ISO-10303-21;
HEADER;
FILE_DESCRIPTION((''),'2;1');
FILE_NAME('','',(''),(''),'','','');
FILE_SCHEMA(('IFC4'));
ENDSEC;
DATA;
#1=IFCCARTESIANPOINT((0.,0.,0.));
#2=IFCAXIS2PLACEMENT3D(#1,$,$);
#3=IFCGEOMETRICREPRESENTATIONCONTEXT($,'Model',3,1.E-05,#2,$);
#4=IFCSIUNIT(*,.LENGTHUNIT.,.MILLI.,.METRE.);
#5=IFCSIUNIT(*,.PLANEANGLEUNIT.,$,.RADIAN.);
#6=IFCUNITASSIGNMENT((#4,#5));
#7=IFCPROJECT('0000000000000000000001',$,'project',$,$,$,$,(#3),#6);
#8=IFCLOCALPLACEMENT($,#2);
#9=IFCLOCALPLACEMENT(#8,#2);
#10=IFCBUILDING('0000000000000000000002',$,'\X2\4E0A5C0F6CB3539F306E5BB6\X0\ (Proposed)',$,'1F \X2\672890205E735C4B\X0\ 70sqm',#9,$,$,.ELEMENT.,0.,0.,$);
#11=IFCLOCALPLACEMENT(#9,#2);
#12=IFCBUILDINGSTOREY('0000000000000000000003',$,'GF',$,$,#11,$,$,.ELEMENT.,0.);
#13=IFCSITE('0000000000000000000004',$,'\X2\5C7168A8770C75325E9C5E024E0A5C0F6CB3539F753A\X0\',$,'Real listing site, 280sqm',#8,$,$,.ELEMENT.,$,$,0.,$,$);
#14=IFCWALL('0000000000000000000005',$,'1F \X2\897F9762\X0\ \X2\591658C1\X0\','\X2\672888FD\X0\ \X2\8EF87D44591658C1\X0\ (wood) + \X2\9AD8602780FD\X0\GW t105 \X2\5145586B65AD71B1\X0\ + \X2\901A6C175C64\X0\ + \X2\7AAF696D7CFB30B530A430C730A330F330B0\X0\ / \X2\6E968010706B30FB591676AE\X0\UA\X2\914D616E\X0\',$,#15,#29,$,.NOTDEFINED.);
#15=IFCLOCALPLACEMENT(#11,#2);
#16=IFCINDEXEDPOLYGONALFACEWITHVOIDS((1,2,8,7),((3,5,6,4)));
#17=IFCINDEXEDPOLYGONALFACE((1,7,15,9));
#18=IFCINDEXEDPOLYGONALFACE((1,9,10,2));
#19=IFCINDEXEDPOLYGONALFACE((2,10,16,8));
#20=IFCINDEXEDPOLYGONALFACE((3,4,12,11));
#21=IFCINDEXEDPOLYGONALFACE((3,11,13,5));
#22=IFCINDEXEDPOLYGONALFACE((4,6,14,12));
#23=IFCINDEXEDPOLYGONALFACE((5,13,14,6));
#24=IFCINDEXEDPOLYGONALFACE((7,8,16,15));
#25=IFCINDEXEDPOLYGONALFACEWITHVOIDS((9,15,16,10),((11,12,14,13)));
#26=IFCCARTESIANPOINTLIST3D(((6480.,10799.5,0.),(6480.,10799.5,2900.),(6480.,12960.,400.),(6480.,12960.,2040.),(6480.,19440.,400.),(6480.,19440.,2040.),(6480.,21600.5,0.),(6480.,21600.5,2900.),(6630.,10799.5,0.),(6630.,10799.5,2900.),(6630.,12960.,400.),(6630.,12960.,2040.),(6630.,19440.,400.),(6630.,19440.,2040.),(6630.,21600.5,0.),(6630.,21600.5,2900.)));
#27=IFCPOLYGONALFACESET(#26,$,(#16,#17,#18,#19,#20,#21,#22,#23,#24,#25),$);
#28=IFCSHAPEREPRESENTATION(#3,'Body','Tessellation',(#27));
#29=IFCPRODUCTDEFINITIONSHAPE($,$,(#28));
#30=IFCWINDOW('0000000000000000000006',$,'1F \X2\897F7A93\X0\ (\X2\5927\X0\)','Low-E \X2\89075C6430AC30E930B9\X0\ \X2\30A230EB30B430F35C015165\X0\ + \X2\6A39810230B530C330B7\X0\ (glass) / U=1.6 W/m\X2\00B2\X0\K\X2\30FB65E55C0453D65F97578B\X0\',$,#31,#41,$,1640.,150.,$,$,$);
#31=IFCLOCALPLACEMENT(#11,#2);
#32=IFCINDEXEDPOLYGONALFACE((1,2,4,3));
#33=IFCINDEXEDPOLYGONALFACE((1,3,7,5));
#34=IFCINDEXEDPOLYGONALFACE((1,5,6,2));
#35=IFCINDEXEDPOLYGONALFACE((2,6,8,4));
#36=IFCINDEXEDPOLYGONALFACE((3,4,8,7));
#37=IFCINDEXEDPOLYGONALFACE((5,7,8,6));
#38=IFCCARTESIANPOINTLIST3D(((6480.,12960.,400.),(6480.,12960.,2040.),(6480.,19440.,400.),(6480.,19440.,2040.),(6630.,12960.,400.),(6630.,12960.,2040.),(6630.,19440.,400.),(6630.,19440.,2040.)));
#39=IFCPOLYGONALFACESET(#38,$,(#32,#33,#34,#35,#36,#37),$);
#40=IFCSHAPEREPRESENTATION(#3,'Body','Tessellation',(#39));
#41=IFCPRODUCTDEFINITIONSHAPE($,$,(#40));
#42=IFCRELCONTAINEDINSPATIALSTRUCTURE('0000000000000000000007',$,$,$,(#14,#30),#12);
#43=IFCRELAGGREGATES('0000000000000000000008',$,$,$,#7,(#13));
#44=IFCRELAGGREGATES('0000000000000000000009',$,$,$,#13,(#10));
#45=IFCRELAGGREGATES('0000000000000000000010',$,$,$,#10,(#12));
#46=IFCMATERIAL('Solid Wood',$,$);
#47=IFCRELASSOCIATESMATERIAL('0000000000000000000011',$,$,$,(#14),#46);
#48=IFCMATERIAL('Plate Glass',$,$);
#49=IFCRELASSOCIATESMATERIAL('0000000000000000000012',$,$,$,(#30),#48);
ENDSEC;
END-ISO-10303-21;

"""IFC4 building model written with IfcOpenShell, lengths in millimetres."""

from ifc_helpers import new_model, si_unit, frame, frame_2d, origin, place, context, project, spatial, rectangle, extrude, material, element, fill, save


model = new_model("IFC4")

# Units and contexts
model_context = context("Model", 3, precision=1e-05, world=origin())
ifc_project = project(units=[si_unit("LENGTHUNIT", "METRE", prefix="MILLI"), si_unit("PLANEANGLEUNIT", "RADIAN")], contexts=[model_context])

# Site, building, storey
site_placement = place(None, origin())
site = spatial("IfcSite", under=ifc_project, at=site_placement, Name="山梨県甲府市上小河原町", ObjectType="Real listing site, 280sqm", CompositionType="ELEMENT", RefElevation=0.0)
building_placement = place(site_placement, origin())
building = spatial("IfcBuilding", under=site, at=building_placement, Name="上小河原の家 (Proposed)", ObjectType="1F 木造平屋 70sqm", CompositionType="ELEMENT", ElevationOfRefHeight=0.0, ElevationOfTerrain=0.0)
storey_placement = place(building_placement, origin())
storey = spatial("IfcBuildingStorey", under=building, at=storey_placement, Name="GF", CompositionType="ELEMENT", Elevation=0.0)

# Shared definitions
ifc_material_1 = material(Name="Solid Wood")

# Shared definitions
ifc_material_2 = material(Name="Plate Glass")

# Wall, opening, window
wall_1_placement = place(storey_placement, frame((3240.0, 5400.0, 0.0)))
wall_1 = element("IfcWall", 1, at=wall_1_placement, inside=storey, material=ifc_material_1, Name="1F 西面 外壁", Description="木製 軸組外壁 (wood) + 高性能GW t105 充填断熱 + 通気層 + 窯業系サイディング / 準耐火・外皮UA配慮", PredefinedType="NOTDEFINED", context=model_context, shape_type="SweptSolid", body=[
    extrude(rectangle(XDim=150.0, YDim=10801.0, at=frame_2d((75.0, 5400.0))), frame((3240.0, 5400.0, 0.0)), (0.0, 0.0, 1.0), 2900.0),
])
opening_1_placement = place(storey_placement, frame((3240.0, 6480.0, 200.0)))
opening_1 = element("IfcOpeningElement", 2, at=opening_1_placement, cuts=wall_1, PredefinedType="NOTDEFINED", context=model_context, shape_type="SweptSolid", body=[
    extrude(rectangle(XDim=150.0, YDim=6480.0, at=frame_2d((75.0, 3240.0))), frame((3240.0, 6480.0, 200.0)), (0.0, 0.0, 1.0), 1640.0),
])
window_1_placement = place(storey_placement, frame((3240.0, 6480.0, 200.0)))
window_1 = element("IfcWindow", 3, at=window_1_placement, inside=storey, material=ifc_material_2, Name="1F 西窓 (大)", Description="Low-E 複層ガラス アルゴン封入 + 樹脂サッシ (glass) / U=1.6 W/m²K・日射取得型", OverallHeight=1640.0, OverallWidth=150.0, context=model_context, shape_type="SweptSolid", body=[
    extrude(rectangle(XDim=150.0, YDim=6480.0, at=frame_2d((75.0, 3240.0))), frame((3240.0, 6480.0, 200.0)), (0.0, 0.0, 1.0), 1640.0),
])
fill(opening_1, window_1)

save(model, "model.ifc")
